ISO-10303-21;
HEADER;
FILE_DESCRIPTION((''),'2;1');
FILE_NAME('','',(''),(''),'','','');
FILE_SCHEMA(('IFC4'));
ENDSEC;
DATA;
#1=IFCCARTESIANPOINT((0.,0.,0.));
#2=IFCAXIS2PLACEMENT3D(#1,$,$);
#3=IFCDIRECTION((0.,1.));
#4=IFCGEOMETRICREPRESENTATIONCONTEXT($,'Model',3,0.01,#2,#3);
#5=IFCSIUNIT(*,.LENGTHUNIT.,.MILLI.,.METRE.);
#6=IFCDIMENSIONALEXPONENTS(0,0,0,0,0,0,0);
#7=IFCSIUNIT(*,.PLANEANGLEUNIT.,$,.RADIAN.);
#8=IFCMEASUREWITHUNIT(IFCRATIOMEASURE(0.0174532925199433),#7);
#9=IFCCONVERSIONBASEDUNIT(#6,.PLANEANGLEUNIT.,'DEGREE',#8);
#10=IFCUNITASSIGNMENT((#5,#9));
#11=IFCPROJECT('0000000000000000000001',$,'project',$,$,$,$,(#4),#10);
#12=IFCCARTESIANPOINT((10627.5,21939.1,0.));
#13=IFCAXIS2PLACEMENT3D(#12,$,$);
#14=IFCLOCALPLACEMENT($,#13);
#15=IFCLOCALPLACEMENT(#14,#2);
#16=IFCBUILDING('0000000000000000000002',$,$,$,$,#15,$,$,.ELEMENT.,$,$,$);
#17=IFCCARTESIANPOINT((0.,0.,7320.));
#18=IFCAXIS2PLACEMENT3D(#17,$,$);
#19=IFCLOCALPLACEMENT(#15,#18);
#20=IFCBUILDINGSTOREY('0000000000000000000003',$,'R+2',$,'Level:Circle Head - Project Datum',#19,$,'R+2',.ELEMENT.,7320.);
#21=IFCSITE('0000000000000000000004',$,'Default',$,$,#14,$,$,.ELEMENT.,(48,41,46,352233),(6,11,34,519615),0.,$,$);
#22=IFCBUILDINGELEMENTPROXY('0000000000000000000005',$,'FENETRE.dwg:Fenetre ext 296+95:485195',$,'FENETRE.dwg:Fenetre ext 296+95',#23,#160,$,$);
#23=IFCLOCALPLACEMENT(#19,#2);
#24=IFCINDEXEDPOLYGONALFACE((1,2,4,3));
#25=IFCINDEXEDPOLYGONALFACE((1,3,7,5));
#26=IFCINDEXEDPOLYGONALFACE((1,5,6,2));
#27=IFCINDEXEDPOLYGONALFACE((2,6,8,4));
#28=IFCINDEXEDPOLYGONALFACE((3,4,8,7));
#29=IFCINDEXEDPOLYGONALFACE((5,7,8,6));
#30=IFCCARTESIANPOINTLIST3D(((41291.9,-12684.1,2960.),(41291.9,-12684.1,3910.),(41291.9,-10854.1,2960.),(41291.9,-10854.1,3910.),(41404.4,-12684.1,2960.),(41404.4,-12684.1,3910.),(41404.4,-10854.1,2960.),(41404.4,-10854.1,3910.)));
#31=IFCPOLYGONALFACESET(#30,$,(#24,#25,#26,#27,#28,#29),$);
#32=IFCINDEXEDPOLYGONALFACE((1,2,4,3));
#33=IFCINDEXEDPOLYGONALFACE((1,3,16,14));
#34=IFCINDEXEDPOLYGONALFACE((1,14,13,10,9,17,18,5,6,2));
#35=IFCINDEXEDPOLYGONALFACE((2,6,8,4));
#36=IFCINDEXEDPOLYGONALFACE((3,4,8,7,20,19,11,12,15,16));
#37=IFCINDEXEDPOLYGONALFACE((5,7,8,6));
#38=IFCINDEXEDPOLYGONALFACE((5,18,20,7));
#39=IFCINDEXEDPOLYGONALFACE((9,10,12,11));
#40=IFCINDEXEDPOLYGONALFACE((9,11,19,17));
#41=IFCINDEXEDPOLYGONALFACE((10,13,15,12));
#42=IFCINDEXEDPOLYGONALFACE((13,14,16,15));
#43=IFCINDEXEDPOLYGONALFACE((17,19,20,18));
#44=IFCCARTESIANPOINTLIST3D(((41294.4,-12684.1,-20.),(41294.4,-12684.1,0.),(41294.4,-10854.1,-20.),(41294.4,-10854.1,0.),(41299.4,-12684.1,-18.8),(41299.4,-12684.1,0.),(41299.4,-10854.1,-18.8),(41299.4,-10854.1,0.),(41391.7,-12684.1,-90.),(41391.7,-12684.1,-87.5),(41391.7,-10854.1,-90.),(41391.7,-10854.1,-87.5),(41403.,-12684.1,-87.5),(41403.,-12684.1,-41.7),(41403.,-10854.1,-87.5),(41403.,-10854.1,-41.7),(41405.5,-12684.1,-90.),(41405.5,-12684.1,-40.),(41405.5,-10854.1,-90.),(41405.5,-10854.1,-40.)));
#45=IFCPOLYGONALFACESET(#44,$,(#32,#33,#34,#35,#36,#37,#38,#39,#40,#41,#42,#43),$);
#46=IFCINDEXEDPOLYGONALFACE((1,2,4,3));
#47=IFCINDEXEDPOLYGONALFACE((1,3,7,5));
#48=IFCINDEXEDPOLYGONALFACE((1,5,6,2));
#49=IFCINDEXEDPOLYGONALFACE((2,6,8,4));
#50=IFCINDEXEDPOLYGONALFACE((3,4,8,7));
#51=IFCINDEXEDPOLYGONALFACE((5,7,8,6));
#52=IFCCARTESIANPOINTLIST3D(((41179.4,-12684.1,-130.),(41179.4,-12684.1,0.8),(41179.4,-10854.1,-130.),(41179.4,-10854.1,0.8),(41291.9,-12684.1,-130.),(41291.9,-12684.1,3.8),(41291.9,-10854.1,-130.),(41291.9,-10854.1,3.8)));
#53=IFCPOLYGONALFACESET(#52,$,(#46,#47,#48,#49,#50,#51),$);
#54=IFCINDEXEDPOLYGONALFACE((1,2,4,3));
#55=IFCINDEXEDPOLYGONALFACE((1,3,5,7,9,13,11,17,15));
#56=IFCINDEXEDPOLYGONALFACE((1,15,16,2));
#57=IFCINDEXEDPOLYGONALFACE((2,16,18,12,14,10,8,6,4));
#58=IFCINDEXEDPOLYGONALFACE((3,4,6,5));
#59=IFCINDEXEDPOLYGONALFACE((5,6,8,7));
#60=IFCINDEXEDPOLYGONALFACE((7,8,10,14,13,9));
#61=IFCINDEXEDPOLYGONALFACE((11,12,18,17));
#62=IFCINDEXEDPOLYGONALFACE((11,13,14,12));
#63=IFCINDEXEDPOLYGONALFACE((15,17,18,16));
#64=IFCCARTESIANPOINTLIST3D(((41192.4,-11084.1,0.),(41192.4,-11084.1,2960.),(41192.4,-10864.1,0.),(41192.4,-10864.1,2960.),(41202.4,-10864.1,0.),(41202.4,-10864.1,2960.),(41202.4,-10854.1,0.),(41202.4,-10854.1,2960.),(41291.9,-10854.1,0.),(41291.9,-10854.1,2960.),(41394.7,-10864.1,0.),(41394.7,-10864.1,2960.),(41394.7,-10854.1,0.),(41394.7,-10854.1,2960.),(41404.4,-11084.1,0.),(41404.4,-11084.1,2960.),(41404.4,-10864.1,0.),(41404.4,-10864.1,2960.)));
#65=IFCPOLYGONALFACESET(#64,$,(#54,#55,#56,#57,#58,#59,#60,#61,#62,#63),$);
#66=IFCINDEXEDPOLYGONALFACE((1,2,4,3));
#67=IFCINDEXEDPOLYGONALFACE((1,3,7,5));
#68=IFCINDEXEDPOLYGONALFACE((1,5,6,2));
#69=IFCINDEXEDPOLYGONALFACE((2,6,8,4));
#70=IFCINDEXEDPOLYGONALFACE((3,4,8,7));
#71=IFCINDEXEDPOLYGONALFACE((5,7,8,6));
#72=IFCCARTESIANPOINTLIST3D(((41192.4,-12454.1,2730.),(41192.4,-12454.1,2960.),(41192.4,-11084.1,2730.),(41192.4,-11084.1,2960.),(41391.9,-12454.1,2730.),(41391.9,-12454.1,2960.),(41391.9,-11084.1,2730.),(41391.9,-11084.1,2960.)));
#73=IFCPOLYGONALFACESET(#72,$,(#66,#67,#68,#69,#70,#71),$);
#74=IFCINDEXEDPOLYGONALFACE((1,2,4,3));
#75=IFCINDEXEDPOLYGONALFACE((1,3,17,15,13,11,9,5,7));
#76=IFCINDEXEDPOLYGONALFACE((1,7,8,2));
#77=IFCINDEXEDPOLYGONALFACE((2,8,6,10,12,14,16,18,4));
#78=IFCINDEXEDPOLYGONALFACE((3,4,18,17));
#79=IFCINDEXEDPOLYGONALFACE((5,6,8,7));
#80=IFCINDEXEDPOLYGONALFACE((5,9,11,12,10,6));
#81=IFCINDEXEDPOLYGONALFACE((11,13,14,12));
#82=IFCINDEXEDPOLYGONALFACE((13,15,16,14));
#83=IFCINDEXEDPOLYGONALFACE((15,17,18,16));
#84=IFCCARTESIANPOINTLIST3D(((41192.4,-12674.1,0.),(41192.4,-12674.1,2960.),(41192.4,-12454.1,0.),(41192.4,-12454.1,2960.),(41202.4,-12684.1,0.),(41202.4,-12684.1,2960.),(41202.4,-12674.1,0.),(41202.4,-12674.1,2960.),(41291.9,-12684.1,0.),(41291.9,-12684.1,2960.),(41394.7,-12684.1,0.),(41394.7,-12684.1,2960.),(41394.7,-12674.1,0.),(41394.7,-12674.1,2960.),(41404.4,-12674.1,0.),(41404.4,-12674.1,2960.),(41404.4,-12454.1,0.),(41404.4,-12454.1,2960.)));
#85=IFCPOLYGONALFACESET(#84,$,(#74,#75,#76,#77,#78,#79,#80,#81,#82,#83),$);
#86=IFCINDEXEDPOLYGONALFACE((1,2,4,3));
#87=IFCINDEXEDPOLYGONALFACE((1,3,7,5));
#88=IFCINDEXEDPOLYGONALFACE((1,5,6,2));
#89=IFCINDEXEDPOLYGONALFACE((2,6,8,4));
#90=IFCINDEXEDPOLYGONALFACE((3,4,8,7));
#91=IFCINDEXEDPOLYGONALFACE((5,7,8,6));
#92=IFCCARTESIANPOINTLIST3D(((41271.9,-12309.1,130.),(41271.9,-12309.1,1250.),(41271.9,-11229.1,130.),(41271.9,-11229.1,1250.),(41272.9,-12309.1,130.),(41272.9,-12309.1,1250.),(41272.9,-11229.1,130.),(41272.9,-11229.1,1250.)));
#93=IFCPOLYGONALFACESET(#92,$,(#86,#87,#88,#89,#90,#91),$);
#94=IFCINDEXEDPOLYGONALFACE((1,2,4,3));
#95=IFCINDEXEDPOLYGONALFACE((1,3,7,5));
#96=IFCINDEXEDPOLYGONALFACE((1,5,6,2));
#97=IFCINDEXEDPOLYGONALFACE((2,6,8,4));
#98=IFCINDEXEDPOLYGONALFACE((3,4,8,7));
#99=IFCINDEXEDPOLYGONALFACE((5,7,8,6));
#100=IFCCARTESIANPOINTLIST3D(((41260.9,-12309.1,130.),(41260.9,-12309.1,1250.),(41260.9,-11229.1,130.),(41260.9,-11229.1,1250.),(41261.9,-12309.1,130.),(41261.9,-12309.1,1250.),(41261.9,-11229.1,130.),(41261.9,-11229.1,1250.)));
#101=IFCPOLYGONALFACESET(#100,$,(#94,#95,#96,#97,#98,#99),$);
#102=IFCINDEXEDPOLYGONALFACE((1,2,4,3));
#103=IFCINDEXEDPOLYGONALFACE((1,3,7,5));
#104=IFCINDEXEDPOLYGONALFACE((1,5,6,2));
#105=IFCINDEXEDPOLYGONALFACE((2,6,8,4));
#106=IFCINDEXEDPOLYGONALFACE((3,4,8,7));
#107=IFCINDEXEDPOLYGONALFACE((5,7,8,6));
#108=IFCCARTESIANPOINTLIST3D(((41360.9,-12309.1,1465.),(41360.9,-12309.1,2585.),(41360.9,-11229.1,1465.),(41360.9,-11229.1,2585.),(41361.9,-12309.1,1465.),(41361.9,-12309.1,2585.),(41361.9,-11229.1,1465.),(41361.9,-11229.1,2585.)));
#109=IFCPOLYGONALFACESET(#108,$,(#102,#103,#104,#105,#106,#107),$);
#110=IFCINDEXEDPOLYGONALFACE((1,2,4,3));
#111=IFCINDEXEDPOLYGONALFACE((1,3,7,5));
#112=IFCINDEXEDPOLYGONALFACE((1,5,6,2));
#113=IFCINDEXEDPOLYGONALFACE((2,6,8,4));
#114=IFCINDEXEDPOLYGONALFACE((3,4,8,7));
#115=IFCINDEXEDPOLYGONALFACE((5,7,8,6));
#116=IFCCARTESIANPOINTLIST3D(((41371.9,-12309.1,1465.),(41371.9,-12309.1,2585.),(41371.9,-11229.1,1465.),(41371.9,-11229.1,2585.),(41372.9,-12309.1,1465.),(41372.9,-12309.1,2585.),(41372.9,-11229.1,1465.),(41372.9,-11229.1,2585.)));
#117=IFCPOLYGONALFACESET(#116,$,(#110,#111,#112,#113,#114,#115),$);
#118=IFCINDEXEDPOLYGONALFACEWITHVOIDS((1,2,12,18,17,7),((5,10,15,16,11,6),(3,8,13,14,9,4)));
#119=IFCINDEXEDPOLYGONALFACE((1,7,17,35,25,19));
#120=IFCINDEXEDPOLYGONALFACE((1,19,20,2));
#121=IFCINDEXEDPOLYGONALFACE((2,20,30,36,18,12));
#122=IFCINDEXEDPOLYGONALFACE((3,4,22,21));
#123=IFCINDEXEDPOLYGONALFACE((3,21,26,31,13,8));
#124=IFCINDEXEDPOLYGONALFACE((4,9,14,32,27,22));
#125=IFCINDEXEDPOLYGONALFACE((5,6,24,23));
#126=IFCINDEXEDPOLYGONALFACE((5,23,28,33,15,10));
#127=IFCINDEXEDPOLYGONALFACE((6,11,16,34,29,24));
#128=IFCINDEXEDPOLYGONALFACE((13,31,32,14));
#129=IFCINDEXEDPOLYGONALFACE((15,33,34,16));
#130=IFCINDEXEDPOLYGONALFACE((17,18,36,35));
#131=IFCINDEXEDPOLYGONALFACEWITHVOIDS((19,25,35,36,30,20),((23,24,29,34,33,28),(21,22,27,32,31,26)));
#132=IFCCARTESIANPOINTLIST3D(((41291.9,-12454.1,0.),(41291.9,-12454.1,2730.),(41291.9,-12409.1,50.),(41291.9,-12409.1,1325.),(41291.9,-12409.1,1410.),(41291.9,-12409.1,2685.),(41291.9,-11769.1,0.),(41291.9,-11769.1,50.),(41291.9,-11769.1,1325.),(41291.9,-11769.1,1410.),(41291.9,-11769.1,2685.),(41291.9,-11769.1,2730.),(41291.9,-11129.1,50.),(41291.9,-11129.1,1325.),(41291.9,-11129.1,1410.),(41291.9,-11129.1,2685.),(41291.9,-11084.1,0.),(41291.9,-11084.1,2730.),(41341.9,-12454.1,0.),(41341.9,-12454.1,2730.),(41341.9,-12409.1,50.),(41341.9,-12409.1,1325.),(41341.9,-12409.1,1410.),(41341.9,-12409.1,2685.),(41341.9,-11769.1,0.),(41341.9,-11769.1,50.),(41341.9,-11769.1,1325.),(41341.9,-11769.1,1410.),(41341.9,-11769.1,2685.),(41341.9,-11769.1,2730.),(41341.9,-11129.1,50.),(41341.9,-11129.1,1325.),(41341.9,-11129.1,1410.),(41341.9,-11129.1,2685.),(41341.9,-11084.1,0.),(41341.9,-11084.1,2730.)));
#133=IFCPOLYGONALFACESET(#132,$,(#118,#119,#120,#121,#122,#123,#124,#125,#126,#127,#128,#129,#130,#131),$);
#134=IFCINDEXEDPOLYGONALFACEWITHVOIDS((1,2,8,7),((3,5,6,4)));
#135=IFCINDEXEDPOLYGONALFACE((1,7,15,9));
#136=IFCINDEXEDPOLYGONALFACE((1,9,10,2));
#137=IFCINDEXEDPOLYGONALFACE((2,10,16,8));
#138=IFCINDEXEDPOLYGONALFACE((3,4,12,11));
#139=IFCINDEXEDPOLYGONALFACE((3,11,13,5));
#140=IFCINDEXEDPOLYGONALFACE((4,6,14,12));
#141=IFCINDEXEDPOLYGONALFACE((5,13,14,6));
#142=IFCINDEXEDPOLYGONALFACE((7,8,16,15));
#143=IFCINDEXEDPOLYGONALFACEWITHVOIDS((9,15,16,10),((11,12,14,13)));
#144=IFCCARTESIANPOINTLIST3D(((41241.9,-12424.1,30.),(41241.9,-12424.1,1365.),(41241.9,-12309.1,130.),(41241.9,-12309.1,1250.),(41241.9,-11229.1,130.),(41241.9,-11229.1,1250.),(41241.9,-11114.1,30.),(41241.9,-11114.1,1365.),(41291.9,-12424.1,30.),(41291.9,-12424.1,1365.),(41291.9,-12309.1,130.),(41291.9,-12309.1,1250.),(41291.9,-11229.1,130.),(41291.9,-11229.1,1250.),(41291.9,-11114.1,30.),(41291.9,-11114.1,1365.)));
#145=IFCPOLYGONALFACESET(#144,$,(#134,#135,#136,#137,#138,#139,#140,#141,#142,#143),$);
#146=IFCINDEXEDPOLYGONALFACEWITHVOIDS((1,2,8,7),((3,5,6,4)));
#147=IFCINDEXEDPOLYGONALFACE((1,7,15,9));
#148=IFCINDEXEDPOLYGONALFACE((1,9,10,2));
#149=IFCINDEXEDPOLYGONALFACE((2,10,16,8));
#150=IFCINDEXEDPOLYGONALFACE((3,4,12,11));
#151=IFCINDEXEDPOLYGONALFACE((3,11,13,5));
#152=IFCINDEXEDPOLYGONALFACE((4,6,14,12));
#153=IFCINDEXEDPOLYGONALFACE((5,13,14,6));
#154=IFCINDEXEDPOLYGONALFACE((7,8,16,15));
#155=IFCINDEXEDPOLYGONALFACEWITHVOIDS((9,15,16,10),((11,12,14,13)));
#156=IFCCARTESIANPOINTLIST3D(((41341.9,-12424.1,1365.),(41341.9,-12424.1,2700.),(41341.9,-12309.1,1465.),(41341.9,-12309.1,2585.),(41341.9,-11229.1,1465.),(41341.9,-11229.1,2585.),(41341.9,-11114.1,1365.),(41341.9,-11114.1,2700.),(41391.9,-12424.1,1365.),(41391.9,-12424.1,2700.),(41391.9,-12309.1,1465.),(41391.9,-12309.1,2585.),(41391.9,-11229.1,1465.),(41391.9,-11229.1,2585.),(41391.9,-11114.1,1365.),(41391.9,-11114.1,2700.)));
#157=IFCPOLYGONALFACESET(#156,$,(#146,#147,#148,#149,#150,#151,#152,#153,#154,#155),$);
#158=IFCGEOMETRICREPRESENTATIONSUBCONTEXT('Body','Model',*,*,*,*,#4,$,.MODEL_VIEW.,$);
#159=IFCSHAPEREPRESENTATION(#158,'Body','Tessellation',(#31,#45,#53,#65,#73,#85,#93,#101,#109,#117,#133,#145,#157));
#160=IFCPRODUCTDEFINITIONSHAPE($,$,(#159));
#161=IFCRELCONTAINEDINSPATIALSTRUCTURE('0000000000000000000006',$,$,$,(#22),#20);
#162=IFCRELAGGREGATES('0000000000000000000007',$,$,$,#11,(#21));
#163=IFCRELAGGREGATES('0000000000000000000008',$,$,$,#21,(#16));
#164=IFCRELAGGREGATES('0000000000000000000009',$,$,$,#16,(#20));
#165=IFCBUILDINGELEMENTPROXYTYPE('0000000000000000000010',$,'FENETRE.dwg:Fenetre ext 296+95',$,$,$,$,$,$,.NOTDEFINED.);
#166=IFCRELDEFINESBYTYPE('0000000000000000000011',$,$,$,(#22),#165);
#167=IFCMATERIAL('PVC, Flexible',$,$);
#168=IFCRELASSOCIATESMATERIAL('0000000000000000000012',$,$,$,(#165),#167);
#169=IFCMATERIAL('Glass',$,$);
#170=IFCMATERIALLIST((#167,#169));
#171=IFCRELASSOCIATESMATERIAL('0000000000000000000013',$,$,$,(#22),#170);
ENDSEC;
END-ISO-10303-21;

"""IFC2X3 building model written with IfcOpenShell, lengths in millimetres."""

from ifc_helpers import new_model, entity, si_unit, converted_unit, direction, frame, frame_2d, origin, origin_2d_with_axis, place, context, subcontext, project, spatial, polyline, rectangle, outline, extrude, source, transform, mapped, material, material_list, type_object, type_shapes, element, save


model = new_model("IFC2X3")

# Units and contexts
model_context = context("Model", 3, precision=0.01, world=origin(), true_north=direction((0.0, 1.0)))
body_context = subcontext(model_context, "Body", "Model", "MODEL_VIEW")
ifc_project = project(units=[si_unit("LENGTHUNIT", "METRE", prefix="MILLI"), converted_unit("PLANEANGLEUNIT", "DEGREE", entity("IfcRatioMeasure", 0.0174532925199433), si_unit("PLANEANGLEUNIT", "RADIAN"), dimensions=[0, 0, 0, 0, 0, 0, 0])], contexts=[model_context])

# Site, building, storey
site_placement = place(None, frame((10627.5, 21939.1, 0.0)))
site = spatial("IfcSite", under=ifc_project, at=site_placement, Name="Default", CompositionType="ELEMENT", RefLatitude=(48, 41, 46, 352233), RefLongitude=(6, 11, 34, 519615), RefElevation=0.0)
building_placement = place(site_placement, origin())
building = spatial("IfcBuilding", under=site, at=building_placement, CompositionType="ELEMENT")
storey_placement = place(building_placement, frame((0.0, 0.0, 7320.0)))
storey = spatial("IfcBuildingStorey", under=building, at=storey_placement, Name="R+2", ObjectType="Level:Circle Head - Project Datum", LongName="R+2", CompositionType="ELEMENT", Elevation=7320.0)

# Building element proxy
ifc_material_1 = material(Name="PVC, Flexible")
ifc_material_2 = material(Name="Glass")
building_element_proxy_type_1 = type_object("IfcBuildingElementProxyType", Name="FENETRE.dwg:Fenetre ext 296+95", PredefinedType="NOTDEFINED", material=ifc_material_1)
shared_shape_1 = source(origin(), body_context, "Body", "SweptSolid", [
    extrude(rectangle(XDim=112.5, YDim=1830.0, at=origin_2d_with_axis()), frame((-10.4, -56.3, 2960.0), z_axis=(0.0, 0.0, 1.0), x_axis=(0.0, 1.0, 0.0)), (0.0, 0.0, 1.0), 950.0),
    extrude(outline(polyline([(27.5, -64.4), (47.5, -64.4), (47.5, -59.4), (28.8, -59.4), (7.5, 46.7), (-42.5, 46.7), (-42.5, 32.9), (-40.0, 32.9), (-40.0, 44.2), (5.8, 44.2), (27.5, -64.4)])), frame((-925.4, -66.9, -47.5), z_axis=(1.0, 0.0, 0.0), x_axis=(0.0, 0.0, 1.0)), (0.0, 0.0, 1.0), 1830.0),
    extrude(outline(polyline([(-54.5, -66.1), (58.0, -66.1), (54.5, 67.6), (-58.0, 64.6), (-54.5, -66.1)])), frame((-925.4, 56.3, -63.8), z_axis=(1.0, 0.0, 0.0), x_axis=(0.0, -0.999645, 0.02665)), (0.0, 0.0, 1.0), 1830.0),
    extrude(outline(polyline([(-97.0, -55.6), (5.9, -55.6), (95.4, -55.6), (95.4, -45.6), (105.4, -45.6), (105.4, 174.4), (-106.6, 174.4), (-106.6, -45.6), (-97.0, -45.6), (-97.0, -55.6)])), frame((849.0, -5.9, 0.0), z_axis=(0.0, 0.0, 1.0), x_axis=(0.0, 1.0, 0.0)), (0.0, 0.0, 1.0), 2960.0),
    extrude(rectangle(XDim=1370.0, YDim=199.5, at=origin_2d_with_axis()), frame((-10.4, -0.3, 2730.0), z_axis=(0.0, 0.0, 1.0), x_axis=(-1.0, 0.0, 0.0)), (0.0, 0.0, 1.0), 230.0),
    extrude(outline(polyline([(-55.6, 97.0), (-55.6, -5.9), (-55.6, -95.4), (-45.6, -95.4), (-45.6, -105.4), (174.4, -105.4), (174.4, 106.6), (-45.6, 106.6), (-45.6, 97.0), (-55.6, 97.0)])), frame((-869.9, -5.9, 0.0), z_axis=(0.0, 0.0, -1.0), x_axis=(1.0, 0.0, 0.0)), (0.0, 0.0, -1.0), 2960.0),
    extrude(rectangle(XDim=1080.0, YDim=1.0, at=origin_2d_with_axis()), frame((-10.4, 19.5, 130.0), z_axis=(0.0, 0.0, 1.0), x_axis=(-1.0, 0.0, 0.0)), (0.0, 0.0, 1.0), 1120.0),
    extrude(rectangle(XDim=1080.0, YDim=1.0, at=origin_2d_with_axis()), frame((-10.4, 30.5, 130.0), z_axis=(0.0, 0.0, 1.0), x_axis=(-1.0, 0.0, 0.0)), (0.0, 0.0, 1.0), 1120.0),
    extrude(rectangle(XDim=1080.0, YDim=1.0, at=frame_2d((0.0, 0.0), x_axis=(1.0, 0.0))), frame((-10.4, -69.5, 1465.0), z_axis=(0.0, 0.0, 1.0), x_axis=(-1.0, 0.0, 0.0)), (0.0, 0.0, 1.0), 1120.0),
    extrude(rectangle(XDim=1080.0, YDim=1.0, at=frame_2d((0.0, 0.0), x_axis=(1.0, 0.0))), frame((-10.4, -80.5, 1465.0), z_axis=(0.0, 0.0, 1.0), x_axis=(-1.0, 0.0, 0.0)), (0.0, 0.0, 1.0), 1120.0),
    extrude(outline(polyline([(-685.0, -1365.0), (0.0, -1365.0), (685.0, -1365.0), (685.0, 1365.0), (0.0, 1365.0), (-685.0, 1365.0), (-685.0, -1365.0)]), holes=[polyline([(-640.0, -1320.0), (-640.0, -45.0), (0.0, -45.0), (640.0, -45.0), (640.0, -1320.0), (0.0, -1320.0), (-640.0, -1320.0)]), polyline([(-640.0, 40.0), (-640.0, 1315.0), (0.0, 1315.0), (640.0, 1315.0), (640.0, 40.0), (0.0, 40.0), (-640.0, 40.0)])]), frame((-10.4, -50.0, 1365.0), z_axis=(0.0, 1.0, 0.0), x_axis=(1.0, 0.0, 0.0)), (0.0, 0.0, 1.0), 50.0),
    extrude(outline(polyline([(-655.0, -667.5), (655.0, -667.5), (655.0, 667.5), (-655.0, 667.5), (-655.0, -667.5)]), holes=[polyline([(-540.0, 552.5), (540.0, 552.5), (540.0, -567.5), (-540.0, -567.5), (-540.0, 552.5)])]), frame((-10.4, 0.0, 697.5), z_axis=(0.0, 1.0, 0.0), x_axis=(-1.0, 0.0, 0.0)), (0.0, 0.0, 1.0), 50.0),
    extrude(outline(polyline([(-655.0, -667.5), (655.0, -667.5), (655.0, 667.5), (-655.0, 667.5), (-655.0, -667.5)]), holes=[polyline([(-540.0, 552.5), (540.0, 552.5), (540.0, -567.5), (-540.0, -567.5), (-540.0, 552.5)])]), frame((-10.4, -100.0, 2032.5), z_axis=(0.0, 1.0, 0.0), x_axis=(-1.0, 0.0, 0.0)), (0.0, 0.0, 1.0), 50.0),
])
type_shapes(building_element_proxy_type_1, [shared_shape_1])
ifc_material_list_1 = material_list([ifc_material_1, ifc_material_2])
proxy_1_placement = place(storey_placement, frame((41291.9, -11758.7, 0.0), z_axis=(0.0, 0.0, 1.0), x_axis=(0.0, 1.0, 0.0)))
element("IfcBuildingElementProxy", 1, at=proxy_1_placement, inside=storey, type_object=building_element_proxy_type_1, material=ifc_material_list_1, Name="FENETRE.dwg:Fenetre ext 296+95:485195", ObjectType="FENETRE.dwg:Fenetre ext 296+95", context=body_context, shape_type="MappedRepresentation", body=[
    mapped(shared_shape_1, transform((0.0, 0.0, 0.0), scale=1.0)),
])

save(model, "model.ifc")
